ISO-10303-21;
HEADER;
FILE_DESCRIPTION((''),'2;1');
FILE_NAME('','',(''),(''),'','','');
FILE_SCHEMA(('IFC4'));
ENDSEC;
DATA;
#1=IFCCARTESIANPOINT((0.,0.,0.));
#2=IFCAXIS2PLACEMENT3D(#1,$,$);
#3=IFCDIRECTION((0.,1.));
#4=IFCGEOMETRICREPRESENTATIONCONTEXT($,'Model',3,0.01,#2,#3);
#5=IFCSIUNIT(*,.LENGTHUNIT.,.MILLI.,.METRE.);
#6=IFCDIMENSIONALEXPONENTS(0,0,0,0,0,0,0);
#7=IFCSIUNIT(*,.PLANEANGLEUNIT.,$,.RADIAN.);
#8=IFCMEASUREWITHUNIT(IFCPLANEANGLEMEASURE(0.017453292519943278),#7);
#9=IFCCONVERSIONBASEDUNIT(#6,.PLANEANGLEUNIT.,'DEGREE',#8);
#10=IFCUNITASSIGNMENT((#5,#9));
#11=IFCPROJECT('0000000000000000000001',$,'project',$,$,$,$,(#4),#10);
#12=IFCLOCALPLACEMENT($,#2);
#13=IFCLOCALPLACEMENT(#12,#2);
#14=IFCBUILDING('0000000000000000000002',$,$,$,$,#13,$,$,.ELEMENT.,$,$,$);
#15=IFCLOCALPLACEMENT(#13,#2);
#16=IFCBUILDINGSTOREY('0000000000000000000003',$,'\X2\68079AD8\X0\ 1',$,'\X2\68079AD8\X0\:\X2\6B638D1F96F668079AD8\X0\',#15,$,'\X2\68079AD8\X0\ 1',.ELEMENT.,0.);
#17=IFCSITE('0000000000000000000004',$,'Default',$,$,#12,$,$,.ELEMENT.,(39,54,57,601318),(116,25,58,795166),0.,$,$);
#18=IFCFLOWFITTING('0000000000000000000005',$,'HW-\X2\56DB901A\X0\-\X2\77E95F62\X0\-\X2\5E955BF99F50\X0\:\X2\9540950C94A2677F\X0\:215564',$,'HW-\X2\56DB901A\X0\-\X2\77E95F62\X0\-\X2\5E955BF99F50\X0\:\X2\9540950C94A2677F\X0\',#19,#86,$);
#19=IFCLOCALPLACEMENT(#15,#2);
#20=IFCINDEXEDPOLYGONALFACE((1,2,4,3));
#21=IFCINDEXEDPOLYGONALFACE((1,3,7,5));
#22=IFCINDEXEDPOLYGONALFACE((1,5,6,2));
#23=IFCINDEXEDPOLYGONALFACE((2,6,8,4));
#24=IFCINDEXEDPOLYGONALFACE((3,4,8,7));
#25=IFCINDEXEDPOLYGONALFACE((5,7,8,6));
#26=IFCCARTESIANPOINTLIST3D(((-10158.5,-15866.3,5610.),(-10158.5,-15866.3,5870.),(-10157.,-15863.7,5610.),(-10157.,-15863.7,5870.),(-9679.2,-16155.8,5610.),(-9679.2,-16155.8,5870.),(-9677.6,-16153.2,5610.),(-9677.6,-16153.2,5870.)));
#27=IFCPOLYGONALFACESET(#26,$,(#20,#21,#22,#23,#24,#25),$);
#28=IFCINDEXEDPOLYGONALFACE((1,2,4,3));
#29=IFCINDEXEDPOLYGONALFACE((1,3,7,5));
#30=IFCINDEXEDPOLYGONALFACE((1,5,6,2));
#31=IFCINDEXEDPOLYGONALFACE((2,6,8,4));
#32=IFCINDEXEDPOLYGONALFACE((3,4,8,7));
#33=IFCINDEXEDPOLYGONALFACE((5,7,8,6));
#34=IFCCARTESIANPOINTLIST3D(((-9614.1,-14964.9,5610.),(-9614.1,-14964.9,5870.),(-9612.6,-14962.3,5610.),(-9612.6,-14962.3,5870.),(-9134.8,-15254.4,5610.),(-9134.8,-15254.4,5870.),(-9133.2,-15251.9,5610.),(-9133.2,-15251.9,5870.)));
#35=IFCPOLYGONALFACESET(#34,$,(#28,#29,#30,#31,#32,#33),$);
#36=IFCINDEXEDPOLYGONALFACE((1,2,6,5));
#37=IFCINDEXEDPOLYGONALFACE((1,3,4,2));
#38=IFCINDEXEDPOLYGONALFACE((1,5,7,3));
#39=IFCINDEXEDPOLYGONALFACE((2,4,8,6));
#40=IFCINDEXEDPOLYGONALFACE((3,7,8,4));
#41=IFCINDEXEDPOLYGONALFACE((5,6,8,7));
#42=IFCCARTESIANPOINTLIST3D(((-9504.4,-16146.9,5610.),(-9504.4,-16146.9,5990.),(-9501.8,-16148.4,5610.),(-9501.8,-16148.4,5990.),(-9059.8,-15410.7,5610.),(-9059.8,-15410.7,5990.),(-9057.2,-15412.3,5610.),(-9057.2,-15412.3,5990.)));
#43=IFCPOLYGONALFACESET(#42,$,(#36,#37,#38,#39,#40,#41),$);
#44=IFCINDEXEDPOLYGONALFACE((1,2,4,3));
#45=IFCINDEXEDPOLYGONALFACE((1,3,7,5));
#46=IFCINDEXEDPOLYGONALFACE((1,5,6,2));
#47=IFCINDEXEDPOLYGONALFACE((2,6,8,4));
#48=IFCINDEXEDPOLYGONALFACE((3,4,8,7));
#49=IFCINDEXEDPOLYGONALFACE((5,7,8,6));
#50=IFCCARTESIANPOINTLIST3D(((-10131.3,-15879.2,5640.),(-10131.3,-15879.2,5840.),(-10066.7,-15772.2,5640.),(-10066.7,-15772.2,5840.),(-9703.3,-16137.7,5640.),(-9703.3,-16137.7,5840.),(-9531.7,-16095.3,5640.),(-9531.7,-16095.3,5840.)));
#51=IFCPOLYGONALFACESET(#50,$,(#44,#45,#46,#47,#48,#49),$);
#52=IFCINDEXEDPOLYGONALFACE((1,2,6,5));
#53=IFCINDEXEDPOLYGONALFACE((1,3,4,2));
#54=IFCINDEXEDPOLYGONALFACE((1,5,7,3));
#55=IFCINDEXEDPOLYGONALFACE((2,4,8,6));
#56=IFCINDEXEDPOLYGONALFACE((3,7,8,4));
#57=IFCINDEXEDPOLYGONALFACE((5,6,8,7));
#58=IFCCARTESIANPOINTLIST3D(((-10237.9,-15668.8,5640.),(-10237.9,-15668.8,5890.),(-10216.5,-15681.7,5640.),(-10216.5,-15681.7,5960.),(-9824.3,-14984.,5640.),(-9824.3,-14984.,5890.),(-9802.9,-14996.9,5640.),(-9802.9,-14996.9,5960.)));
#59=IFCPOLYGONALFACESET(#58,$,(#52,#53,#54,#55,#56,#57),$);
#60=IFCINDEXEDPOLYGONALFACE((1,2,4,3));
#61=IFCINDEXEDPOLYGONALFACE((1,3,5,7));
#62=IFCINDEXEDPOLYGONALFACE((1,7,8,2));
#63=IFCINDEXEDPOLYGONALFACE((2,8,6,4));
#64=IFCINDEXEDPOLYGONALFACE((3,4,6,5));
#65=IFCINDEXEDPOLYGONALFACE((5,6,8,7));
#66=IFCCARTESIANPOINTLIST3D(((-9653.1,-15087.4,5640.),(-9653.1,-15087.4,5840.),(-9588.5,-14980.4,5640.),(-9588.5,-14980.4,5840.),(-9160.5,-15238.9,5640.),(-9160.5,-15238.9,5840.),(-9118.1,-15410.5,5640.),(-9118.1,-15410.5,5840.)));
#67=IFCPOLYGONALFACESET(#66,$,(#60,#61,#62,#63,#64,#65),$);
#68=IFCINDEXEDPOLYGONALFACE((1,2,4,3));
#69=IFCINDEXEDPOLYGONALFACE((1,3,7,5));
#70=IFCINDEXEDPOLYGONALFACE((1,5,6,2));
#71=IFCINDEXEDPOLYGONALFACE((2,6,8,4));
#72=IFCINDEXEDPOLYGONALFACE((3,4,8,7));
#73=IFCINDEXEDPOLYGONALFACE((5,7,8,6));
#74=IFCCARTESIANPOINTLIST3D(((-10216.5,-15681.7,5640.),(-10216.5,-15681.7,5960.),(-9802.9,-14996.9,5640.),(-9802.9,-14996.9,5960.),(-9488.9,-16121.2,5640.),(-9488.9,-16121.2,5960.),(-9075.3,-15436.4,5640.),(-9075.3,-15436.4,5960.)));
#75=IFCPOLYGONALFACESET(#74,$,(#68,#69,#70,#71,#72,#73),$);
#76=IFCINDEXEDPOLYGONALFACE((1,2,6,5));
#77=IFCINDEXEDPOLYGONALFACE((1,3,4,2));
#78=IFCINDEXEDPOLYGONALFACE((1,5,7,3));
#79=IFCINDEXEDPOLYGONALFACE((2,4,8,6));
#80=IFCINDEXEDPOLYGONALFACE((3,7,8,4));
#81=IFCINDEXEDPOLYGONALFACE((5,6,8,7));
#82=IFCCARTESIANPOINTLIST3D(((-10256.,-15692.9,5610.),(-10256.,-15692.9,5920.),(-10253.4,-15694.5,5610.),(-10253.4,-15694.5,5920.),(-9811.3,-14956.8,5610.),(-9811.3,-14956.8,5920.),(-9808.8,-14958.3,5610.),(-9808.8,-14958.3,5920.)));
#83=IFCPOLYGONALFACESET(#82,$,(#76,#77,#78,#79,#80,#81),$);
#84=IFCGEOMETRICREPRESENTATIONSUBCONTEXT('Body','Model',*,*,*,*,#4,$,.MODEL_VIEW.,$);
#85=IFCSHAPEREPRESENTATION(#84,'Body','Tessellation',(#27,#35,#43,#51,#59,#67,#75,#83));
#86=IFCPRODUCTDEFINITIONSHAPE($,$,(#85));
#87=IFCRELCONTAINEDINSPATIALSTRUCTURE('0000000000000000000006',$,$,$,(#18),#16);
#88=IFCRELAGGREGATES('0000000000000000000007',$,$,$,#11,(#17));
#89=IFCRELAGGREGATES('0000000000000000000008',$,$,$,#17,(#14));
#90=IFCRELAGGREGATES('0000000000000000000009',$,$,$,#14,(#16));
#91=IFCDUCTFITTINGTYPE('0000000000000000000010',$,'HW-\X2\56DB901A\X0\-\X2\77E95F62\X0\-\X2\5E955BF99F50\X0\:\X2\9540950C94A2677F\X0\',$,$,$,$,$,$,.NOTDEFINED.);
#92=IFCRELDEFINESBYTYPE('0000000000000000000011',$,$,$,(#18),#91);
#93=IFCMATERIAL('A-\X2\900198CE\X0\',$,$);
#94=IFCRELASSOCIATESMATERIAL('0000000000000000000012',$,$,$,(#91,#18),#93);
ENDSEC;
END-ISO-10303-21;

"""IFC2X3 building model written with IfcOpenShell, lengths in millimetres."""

from ifc_helpers import new_model, entity, si_unit, converted_unit, direction, frame, frame_2d, origin, origin_2d_with_axis, place, context, subcontext, project, spatial, polyline, rectangle, outline, extrude, source, transform, mapped, material, type_object, type_shapes, element, save


model = new_model("IFC2X3")

# Units and contexts
model_context = context("Model", 3, precision=0.01, world=origin(), true_north=direction((0.0, 1.0)))
body_context = subcontext(model_context, "Body", "Model", "MODEL_VIEW")
ifc_project = project(units=[si_unit("LENGTHUNIT", "METRE", prefix="MILLI"), converted_unit("PLANEANGLEUNIT", "DEGREE", entity("IfcPlaneAngleMeasure", 0.017453292519943278), si_unit("PLANEANGLEUNIT", "RADIAN"), dimensions=[0, 0, 0, 0, 0, 0, 0])], contexts=[model_context])

# Site, building, storey
site_placement = place(None, origin())
site = spatial("IfcSite", under=ifc_project, at=site_placement, Name="Default", CompositionType="ELEMENT", RefLatitude=(39, 54, 57, 601318), RefLongitude=(116, 25, 58, 795166), RefElevation=0.0)
building_placement = place(site_placement, origin())
building = spatial("IfcBuilding", under=site, at=building_placement, CompositionType="ELEMENT")
storey_placement = place(building_placement, origin())
storey = spatial("IfcBuildingStorey", under=building, at=storey_placement, Name="标高 1", ObjectType="标高:正负零标高", LongName="标高 1", CompositionType="ELEMENT", Elevation=0.0)

# Shared definitions
ifc_material = material(Name="A-送风")

# Flow fitting
duct_fitting_type_1 = type_object("IfcDuctFittingType", Name="HW-四通-矩形-底对齐:镀锌钢板", PredefinedType="NOTDEFINED", material=ifc_material)
shared_shape_1 = source(origin(), body_context, "Body", "SweptSolid", [
    extrude(rectangle(XDim=560.0, YDim=3.0, at=origin_2d_with_axis()), frame((0.0, 526.5, -190.0), z_axis=(0.0, 0.0, 1.0), x_axis=(-1.0, 0.0, 0.0)), (0.0, 0.0, 1.0), 260.0),
    extrude(rectangle(XDim=560.0, YDim=3.0, at=frame_2d((0.0, 0.0), x_axis=(1.0, 0.0))), frame((0.0, -526.5, -190.0), z_axis=(0.0, 0.0, 1.0), x_axis=(-1.0, 0.0, 0.0)), (0.0, 0.0, 1.0), 260.0),
    extrude(rectangle(XDim=860.0, YDim=3.0, at=frame_2d((0.0, 0.0), x_axis=(1.0, 0.0))), frame((-426.5, 0.0, -190.0), z_axis=(0.0, 0.0, 1.0), x_axis=(0.0, 1.0, 0.0)), (0.0, 0.0, 1.0), 380.0),
    extrude(outline(polyline([(110.5, -198.9), (287.3, -198.9), (-154.7, 243.1), (-243.1, 154.7), (110.5, -198.9)])), frame((-31.2, 462.5, -160.0), z_axis=(0.0, 0.0, 1.0), x_axis=(-0.707107, -0.707107, 0.0)), (0.0, 0.0, 1.0), 200.0),
    extrude(outline(polyline([(-12.5, -142.5), (12.5, -142.5), (12.5, 177.5), (-12.5, 107.5), (-12.5, -142.5)])), frame((437.5, -400.0, -17.5), z_axis=(0.0, 1.0, 0.0), x_axis=(-1.0, 0.0, 0.0)), (0.0, 0.0, 1.0), 800.0),
    extrude(outline(polyline([(-62.5, -281.2), (62.5, -281.2), (62.5, 343.8), (-62.5, 218.7), (-62.5, -281.2)])), frame((-31.3, -462.5, -160.0), z_axis=(0.0, 0.0, 1.0), x_axis=(0.0, 1.0, 0.0)), (0.0, 0.0, 1.0), 200.0),
    extrude(rectangle(XDim=850.0, YDim=800.0, at=origin_2d_with_axis()), frame((0.0, 0.0, -160.0), z_axis=(0.0, 0.0, 1.0), x_axis=(-1.0, 0.0, 0.0)), (0.0, 0.0, 1.0), 320.0),
    extrude(rectangle(XDim=860.0, YDim=3.0, at=frame_2d((0.0, 0.0), x_axis=(1.0, 0.0))), frame((451.5, 0.0, -190.0), z_axis=(0.0, 0.0, 1.0), x_axis=(0.0, 1.0, 0.0)), (0.0, 0.0, 1.0), 310.0),
])
type_shapes(duct_fitting_type_1, [shared_shape_1])
flow_fitting_1_placement = place(storey_placement, frame((-9645.9, -15559.1, 5800.0), z_axis=(0.0, 0.0, 1.0), x_axis=(-0.85599, 0.516993, 0.0)))
element("IfcFlowFitting", 1, at=flow_fitting_1_placement, inside=storey, type_object=duct_fitting_type_1, material=ifc_material, Name="HW-四通-矩形-底对齐:镀锌钢板:215564", ObjectType="HW-四通-矩形-底对齐:镀锌钢板", context=body_context, shape_type="MappedRepresentation", body=[
    mapped(shared_shape_1, transform((0.0, 0.0, 0.0), scale=1.0)),
])

save(model, "model.ifc")
